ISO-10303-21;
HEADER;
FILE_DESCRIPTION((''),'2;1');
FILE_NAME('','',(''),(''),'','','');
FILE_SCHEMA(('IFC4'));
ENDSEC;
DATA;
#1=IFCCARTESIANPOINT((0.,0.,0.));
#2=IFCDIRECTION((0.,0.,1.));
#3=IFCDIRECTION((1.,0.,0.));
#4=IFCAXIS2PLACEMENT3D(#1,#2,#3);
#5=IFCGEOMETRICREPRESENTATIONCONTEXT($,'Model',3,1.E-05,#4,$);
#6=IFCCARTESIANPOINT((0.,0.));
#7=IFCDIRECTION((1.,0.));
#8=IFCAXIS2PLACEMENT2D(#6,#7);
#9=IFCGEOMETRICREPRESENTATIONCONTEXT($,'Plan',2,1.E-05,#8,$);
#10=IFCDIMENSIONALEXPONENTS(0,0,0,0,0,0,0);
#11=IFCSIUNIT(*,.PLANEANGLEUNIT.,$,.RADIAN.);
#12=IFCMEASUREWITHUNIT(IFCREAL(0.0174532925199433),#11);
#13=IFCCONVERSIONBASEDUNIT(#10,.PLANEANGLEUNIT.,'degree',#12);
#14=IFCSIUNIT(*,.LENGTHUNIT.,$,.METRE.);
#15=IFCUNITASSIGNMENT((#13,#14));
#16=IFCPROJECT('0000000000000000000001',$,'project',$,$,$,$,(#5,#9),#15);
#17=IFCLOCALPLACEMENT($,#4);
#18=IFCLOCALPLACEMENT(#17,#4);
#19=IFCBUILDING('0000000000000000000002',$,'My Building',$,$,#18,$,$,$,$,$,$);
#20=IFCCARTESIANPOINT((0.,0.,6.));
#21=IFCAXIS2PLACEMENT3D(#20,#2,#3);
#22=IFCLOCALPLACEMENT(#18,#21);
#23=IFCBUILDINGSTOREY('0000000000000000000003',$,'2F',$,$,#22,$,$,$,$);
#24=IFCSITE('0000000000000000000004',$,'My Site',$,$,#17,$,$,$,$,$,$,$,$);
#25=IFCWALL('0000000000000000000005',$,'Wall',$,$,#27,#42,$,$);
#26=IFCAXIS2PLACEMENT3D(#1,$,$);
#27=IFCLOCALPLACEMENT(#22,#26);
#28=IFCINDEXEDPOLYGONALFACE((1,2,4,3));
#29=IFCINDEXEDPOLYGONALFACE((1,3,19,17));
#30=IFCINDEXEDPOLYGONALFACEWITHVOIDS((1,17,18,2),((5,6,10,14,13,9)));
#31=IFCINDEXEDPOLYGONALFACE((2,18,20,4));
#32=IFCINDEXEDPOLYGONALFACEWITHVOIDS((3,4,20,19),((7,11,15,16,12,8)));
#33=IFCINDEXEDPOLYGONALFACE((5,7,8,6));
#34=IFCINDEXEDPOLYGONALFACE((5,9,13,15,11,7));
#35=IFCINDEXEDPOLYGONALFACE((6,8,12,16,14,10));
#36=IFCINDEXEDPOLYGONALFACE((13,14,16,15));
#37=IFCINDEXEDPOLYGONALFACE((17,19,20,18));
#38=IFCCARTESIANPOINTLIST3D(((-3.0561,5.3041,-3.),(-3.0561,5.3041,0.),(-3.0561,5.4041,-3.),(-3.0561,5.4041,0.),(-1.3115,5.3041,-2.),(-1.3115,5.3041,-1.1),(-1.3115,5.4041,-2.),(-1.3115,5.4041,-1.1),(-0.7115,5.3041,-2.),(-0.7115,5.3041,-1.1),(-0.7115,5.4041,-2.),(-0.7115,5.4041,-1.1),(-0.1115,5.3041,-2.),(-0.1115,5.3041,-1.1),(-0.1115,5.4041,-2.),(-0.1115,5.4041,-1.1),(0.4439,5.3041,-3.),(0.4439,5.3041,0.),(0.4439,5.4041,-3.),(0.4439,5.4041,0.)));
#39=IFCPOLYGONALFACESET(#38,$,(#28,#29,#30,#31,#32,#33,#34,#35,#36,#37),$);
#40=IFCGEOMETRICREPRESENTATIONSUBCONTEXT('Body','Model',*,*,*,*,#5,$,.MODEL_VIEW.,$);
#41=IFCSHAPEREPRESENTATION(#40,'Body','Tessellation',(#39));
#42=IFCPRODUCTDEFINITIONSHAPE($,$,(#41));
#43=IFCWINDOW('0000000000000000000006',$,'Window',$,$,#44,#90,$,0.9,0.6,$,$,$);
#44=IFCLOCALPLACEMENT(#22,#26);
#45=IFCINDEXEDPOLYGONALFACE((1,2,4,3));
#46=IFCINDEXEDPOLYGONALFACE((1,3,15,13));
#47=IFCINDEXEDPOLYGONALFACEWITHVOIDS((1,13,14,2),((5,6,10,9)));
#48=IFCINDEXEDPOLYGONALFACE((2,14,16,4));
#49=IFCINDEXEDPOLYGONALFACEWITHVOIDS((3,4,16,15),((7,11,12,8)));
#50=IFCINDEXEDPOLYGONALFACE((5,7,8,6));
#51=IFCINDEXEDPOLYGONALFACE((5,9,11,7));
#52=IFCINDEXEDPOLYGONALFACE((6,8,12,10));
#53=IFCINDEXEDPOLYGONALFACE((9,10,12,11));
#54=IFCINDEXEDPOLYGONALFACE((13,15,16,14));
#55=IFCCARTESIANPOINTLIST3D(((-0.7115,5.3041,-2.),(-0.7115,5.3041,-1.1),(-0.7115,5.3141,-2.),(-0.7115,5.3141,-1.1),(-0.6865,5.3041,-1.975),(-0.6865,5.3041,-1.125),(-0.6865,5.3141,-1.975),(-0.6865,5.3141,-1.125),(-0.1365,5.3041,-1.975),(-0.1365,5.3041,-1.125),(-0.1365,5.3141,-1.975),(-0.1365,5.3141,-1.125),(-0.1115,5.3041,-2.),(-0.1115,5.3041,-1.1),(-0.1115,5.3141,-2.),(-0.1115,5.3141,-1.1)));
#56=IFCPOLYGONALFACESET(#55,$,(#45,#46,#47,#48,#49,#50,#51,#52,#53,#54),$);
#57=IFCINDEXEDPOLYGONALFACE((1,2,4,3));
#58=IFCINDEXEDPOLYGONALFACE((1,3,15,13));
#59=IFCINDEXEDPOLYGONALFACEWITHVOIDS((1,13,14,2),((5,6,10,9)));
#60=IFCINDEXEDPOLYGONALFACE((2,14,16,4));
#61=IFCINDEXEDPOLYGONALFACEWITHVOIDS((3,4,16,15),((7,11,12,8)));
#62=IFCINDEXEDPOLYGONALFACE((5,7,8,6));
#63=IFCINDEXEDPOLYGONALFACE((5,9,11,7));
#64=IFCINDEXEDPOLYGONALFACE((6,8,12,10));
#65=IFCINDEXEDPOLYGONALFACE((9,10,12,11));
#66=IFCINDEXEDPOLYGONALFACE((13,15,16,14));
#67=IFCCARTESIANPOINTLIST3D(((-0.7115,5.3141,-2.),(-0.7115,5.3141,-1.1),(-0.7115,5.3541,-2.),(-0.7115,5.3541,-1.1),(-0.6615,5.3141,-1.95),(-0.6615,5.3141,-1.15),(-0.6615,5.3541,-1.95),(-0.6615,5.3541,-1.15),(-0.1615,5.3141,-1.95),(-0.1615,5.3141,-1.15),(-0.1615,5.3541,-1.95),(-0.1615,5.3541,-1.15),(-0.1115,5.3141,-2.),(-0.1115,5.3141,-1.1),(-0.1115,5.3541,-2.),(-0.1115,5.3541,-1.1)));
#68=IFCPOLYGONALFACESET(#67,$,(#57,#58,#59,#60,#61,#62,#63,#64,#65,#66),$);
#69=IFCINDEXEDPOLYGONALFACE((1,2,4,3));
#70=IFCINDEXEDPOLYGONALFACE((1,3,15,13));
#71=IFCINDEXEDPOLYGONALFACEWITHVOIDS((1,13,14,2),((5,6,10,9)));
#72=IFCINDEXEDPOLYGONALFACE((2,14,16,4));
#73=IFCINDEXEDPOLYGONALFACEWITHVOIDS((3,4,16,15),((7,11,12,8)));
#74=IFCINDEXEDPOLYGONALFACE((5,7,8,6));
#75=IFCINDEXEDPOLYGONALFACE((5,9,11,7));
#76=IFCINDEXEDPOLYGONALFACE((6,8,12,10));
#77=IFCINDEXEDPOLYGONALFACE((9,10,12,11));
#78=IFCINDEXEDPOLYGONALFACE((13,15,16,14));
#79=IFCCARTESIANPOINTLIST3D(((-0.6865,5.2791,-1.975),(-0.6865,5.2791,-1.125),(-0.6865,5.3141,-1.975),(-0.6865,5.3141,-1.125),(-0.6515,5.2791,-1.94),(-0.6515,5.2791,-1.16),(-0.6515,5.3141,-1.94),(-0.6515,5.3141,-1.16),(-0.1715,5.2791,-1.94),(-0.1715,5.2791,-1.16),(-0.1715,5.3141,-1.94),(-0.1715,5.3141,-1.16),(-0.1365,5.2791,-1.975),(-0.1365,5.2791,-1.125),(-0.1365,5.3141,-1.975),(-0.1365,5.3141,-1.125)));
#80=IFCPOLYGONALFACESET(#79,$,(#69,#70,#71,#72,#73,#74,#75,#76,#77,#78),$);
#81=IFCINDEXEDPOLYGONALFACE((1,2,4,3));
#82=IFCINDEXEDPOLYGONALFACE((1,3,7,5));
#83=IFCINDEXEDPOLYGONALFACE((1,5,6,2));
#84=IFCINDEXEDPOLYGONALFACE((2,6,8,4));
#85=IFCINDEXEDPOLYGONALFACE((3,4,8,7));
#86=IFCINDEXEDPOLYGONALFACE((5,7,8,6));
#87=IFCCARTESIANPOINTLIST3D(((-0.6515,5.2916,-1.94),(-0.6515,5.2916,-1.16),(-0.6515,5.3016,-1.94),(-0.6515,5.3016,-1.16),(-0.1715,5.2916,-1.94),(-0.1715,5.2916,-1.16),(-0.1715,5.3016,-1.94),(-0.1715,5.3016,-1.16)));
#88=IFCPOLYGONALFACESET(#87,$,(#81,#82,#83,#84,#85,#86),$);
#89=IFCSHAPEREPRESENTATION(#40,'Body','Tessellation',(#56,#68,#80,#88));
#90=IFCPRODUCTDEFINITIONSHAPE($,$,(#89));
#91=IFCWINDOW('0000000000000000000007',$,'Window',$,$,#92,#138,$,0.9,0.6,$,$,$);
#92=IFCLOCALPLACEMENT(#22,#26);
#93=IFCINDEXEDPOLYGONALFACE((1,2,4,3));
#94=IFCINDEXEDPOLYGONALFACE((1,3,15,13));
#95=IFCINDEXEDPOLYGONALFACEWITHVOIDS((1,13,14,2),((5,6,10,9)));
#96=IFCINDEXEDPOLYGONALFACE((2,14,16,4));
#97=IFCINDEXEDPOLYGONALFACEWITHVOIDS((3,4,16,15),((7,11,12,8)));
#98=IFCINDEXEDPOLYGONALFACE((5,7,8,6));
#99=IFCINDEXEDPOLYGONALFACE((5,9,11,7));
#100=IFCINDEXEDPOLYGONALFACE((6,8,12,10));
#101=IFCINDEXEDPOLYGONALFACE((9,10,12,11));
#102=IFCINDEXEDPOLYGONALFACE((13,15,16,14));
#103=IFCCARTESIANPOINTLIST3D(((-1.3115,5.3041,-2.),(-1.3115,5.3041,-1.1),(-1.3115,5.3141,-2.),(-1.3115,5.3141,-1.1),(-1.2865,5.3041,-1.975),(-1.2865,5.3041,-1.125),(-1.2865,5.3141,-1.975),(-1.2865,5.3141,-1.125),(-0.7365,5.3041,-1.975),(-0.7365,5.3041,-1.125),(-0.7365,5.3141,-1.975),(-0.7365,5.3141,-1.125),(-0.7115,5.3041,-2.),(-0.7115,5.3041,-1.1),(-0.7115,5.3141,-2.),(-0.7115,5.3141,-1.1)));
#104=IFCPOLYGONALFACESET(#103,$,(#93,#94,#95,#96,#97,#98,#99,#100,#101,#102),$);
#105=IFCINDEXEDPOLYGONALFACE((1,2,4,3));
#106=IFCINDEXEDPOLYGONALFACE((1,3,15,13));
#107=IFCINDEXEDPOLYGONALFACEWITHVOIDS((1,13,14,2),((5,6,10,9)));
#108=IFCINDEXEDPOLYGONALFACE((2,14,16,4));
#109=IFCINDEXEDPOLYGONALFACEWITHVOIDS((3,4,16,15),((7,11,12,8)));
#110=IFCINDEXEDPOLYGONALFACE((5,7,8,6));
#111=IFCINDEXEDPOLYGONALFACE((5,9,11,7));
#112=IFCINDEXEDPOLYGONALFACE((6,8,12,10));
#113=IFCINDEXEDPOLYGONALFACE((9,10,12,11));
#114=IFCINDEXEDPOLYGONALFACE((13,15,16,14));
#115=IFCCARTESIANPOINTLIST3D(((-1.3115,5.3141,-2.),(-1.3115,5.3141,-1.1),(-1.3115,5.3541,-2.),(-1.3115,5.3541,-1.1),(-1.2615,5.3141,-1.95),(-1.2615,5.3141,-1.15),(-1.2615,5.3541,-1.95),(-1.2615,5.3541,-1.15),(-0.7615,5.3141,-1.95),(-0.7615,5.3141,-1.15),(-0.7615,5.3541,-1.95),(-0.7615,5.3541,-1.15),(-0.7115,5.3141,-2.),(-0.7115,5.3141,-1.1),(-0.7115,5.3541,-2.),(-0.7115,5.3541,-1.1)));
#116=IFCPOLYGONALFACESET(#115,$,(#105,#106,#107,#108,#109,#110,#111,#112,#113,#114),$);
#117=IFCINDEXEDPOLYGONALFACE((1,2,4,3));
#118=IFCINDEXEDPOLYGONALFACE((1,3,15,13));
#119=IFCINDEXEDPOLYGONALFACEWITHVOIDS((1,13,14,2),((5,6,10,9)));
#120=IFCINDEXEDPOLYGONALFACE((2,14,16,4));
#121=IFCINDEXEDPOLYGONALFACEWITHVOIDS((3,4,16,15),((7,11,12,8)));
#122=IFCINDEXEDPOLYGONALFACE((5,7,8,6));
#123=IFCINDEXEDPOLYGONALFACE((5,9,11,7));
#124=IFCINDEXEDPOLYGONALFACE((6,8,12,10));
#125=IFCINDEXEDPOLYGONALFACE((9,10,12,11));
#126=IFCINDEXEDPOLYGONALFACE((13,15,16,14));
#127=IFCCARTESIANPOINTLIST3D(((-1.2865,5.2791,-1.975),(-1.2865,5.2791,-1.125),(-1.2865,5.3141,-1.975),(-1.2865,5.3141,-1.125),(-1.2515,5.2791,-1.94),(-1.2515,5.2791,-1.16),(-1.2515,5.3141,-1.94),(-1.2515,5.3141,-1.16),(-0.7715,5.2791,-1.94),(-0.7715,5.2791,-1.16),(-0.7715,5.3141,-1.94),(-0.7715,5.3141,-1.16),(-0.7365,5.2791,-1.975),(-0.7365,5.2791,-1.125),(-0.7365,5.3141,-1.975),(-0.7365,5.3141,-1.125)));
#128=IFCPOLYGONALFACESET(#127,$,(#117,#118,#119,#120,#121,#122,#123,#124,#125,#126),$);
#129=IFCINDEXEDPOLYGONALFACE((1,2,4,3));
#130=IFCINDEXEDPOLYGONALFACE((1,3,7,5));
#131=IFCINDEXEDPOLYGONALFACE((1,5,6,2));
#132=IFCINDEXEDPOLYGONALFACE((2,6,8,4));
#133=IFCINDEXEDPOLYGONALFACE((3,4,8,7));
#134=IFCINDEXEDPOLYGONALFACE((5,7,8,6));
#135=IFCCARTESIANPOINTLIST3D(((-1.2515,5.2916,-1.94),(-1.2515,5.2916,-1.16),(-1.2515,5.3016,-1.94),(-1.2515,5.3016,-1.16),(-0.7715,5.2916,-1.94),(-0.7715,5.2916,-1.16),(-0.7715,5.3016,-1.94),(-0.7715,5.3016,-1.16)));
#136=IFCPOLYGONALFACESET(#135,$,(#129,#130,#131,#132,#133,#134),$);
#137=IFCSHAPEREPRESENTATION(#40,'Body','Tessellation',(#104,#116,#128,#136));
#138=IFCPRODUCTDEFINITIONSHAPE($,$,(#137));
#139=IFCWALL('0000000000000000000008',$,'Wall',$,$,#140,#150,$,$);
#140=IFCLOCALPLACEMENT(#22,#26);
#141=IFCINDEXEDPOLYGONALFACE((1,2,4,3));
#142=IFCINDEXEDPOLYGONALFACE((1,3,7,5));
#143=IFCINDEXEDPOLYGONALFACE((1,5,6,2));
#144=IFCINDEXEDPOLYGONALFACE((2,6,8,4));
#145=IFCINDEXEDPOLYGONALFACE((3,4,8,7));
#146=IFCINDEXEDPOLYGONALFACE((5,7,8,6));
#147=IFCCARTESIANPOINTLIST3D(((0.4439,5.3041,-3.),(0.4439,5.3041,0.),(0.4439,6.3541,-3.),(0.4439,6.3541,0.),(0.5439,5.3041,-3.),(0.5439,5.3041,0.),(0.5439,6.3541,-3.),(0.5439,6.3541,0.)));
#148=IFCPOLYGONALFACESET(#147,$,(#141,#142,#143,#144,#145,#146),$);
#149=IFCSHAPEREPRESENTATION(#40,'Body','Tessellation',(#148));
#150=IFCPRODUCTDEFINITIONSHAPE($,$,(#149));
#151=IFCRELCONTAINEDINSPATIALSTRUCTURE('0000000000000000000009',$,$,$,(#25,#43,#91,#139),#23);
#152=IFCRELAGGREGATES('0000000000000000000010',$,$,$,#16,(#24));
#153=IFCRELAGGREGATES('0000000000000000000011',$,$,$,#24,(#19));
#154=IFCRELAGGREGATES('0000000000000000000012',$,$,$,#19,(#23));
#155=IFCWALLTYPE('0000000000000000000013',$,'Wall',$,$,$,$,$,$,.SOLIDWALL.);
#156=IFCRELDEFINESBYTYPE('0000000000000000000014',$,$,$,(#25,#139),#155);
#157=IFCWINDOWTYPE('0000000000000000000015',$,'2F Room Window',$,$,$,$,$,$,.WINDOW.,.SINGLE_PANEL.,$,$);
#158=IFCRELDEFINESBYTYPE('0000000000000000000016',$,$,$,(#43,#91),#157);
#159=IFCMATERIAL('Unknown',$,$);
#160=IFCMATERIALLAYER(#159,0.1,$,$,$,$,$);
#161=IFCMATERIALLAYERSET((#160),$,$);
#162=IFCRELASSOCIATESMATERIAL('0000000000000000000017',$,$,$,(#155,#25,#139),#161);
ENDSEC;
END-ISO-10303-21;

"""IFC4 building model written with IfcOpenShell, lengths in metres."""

from ifc_helpers import new_model, entity, si_unit, converted_unit, frame, origin_with_axes, origin_2d_with_axis, place, context, subcontext, project, spatial, line, indexed_curve, outline, extrude, shape, source, transform, mapped, material, layer, layer_set, layer_usage, type_object, type_shapes, element, fill, save


model = new_model("IFC4")

# Units and contexts
model_context = context("Model", 3, precision=1e-05, world=origin_with_axes())
plan_context = context("Plan", 2, precision=1e-05, world=origin_2d_with_axis())
body_context_1 = subcontext(model_context, "Body", "Model", "MODEL_VIEW")
body_context_2 = subcontext(plan_context, "Body", "Plan", "PLAN_VIEW")
ifc_project = project(units=[converted_unit("PLANEANGLEUNIT", "degree", entity("IfcReal", 0.0174532925199433), si_unit("PLANEANGLEUNIT", "RADIAN"), dimensions=[0, 0, 0, 0, 0, 0, 0]), si_unit("LENGTHUNIT", "METRE")], contexts=[model_context, plan_context])

# Site, building, storey
site_placement = place(None, origin_with_axes())
site = spatial("IfcSite", under=ifc_project, at=site_placement, Name="My Site")
building_placement = place(site_placement, origin_with_axes())
building = spatial("IfcBuilding", under=site, at=building_placement, Name="My Building")
storey_placement = place(building_placement, frame((0.0, 0.0, 6.0), z_axis=(0.0, 0.0, 1.0), x_axis=(1.0, 0.0, 0.0)))
storey = spatial("IfcBuildingStorey", under=building, at=storey_placement, Name="2F")

# Shared definitions
ifc_material = material(Name="Unknown")
ifc_layer = layer(ifc_material, 0.1)
ifc_layer_set = layer_set([ifc_layer])
wall_type = type_object("IfcWallType", Name="Wall", PredefinedType="SOLIDWALL", material=ifc_layer_set)

# Wall, openings, windows
shared_shape_1 = source(origin_with_axes(), body_context_1, "Body", "SweptSolid", [
    extrude(outline(indexed_curve([(0.0, 0.0), (0.6, 0.0), (0.6, 0.9), (0.0, 0.9)], segments=[line(1, 2, 3, 4, 1)])), frame((0.0, -0.6, 0.0), z_axis=(0.0, -1.0, 0.0), x_axis=(1.0, 0.0, 0.0)), (0.0, 0.0, -1.0), 1.2),
])
window_type_1 = type_object("IfcWindowType", Name="2F Room Window", PartitioningType="SINGLE_PANEL", PredefinedType="WINDOW")
shared_shape_2 = source(origin_with_axes(), body_context_1, "Body", "SweptSolid", [
    extrude(outline(indexed_curve([(0.0, 0.0), (0.6, 0.0), (0.6, 0.9), (0.0, 0.9)], segments=[line(1, 2, 3, 4, 1)]), holes=[indexed_curve([(0.025, 0.025), (0.575, 0.025), (0.575, 0.875), (0.025, 0.875)], segments=[line(1, 2, 3, 4, 1)])]), frame((0.0, 0.09, 0.0), z_axis=(0.0, -1.0, 0.0), x_axis=(1.0, 0.0, 0.0)), (0.0, 0.0, -1.0), 0.01),
    extrude(outline(indexed_curve([(0.0, 0.0), (0.6, 0.0), (0.6, 0.9), (0.0, 0.9)], segments=[line(1, 2, 3, 4, 1)]), holes=[indexed_curve([(0.05, 0.05), (0.55, 0.05), (0.55, 0.85), (0.05, 0.85)], segments=[line(1, 2, 3, 4, 1)])]), frame((0.0, 0.05, 0.0), z_axis=(0.0, -1.0, 0.0), x_axis=(1.0, 0.0, 0.0)), (0.0, 0.0, -1.0), 0.04),
    extrude(outline(indexed_curve([(0.0, 0.0), (0.55, 0.0), (0.55, 0.85), (0.0, 0.85)], segments=[line(1, 2, 3, 4, 1)]), holes=[indexed_curve([(0.035, 0.035), (0.515, 0.035), (0.515, 0.815), (0.035, 0.815)], segments=[line(1, 2, 3, 4, 1)])]), frame((0.025, 0.09, 0.025), z_axis=(0.0, -1.0, 0.0), x_axis=(1.0, 0.0, 0.0)), (0.0, 0.0, -1.0), 0.035),
    extrude(outline(indexed_curve([(0.035, 0.035), (0.515, 0.035), (0.515, 0.815), (0.035, 0.815)], segments=[line(1, 2, 3, 4, 1)])), frame((0.025, 0.1025, 0.025), z_axis=(0.0, -1.0, 0.0), x_axis=(1.0, 0.0, 0.0)), (0.0, 0.0, -1.0), 0.01),
])
shared_shape_3 = source(origin_with_axes(), body_context_2, "Body", "Curve2D", [
    entity("IfcIndexedPolyCurve", entity("IfcCartesianPointList2D", [[0.05, 0.05], [0.55, 0.05]])),
    entity("IfcIndexedPolyCurve", entity("IfcCartesianPointList2D", [[0.0, 0.1], [0.025, 0.1], [0.025, 0.09], [0.05, 0.09], [0.05, 0.05], [0.0, 0.05]]), [entity("IfcLineIndex", [1, 2, 3, 4, 5, 6, 1])]),
    entity("IfcIndexedPolyCurve", entity("IfcCartesianPointList2D", [[0.6, 0.1], [0.575, 0.1], [0.575, 0.09], [0.55, 0.09], [0.55, 0.05], [0.6, 0.05]]), [entity("IfcLineIndex", [1, 2, 3, 4, 5, 6, 1])]),
    entity("IfcIndexedPolyCurve", entity("IfcCartesianPointList2D", [[0.025, 0.09], [0.06, 0.09], [0.06, 0.125], [0.025, 0.125]]), [entity("IfcLineIndex", [1, 2, 3, 4, 1])]),
    entity("IfcIndexedPolyCurve", entity("IfcCartesianPointList2D", [[0.575, 0.09], [0.54, 0.09], [0.54, 0.125], [0.575, 0.125]]), [entity("IfcLineIndex", [1, 2, 3, 4, 1])]),
    entity("IfcIndexedPolyCurve", entity("IfcCartesianPointList2D", [[0.06, 0.09], [0.54, 0.09]])),
    entity("IfcIndexedPolyCurve", entity("IfcCartesianPointList2D", [[0.06, 0.125], [0.54, 0.125]])),
    entity("IfcIndexedPolyCurve", entity("IfcCartesianPointList2D", [[0.06, 0.1075], [0.54, 0.1075]])),
])
type_shapes(window_type_1, [shared_shape_2, shared_shape_3])
ifc_layer_usage_1 = layer_usage(ifc_layer_set, "AXIS2", "POSITIVE", 0.0)
wall_1_placement = place(storey_placement, frame((0.4439, 5.4041, -3.0), z_axis=(0.0, 0.0, 1.0), x_axis=(-1.0, 0.0, 0.0)))
wall_1 = element("IfcWall", 1, at=wall_1_placement, inside=storey, type_object=wall_type, material=ifc_layer_usage_1, Name="Wall", context=body_context_1, shape_type="SweptSolid", body=[
    extrude(outline(indexed_curve([(0.0, 0.0), (0.0, 0.1), (3.5, 0.1), (3.5, 0.0)], segments=[line(1, 2, 3, 4, 1)])), origin_with_axes(), (0.0, 0.0, 1.0), 3.0),
])
opening_1_placement = place(wall_1_placement, frame((0.5555, 0.0, 1.0), z_axis=(0.0, 0.0, 1.0), x_axis=(1.0, 0.0, 0.0)))
opening_1 = element("IfcOpeningElement", 2, at=opening_1_placement, cuts=wall_1, PredefinedType="OPENING", context=body_context_1, shape_type="MappedRepresentation", body=[
    mapped(shared_shape_1, transform((0.0, 0.0, 0.0), x_axis=(1.0, 0.0, 0.0), y_axis=(0.0, 1.0, 0.0), z_axis=(0.0, 0.0, 1.0), scale=1.0)),
])
opening_2_placement = place(wall_1_placement, frame((1.1555, 0.0, 1.0), z_axis=(0.0, 0.0, 1.0), x_axis=(1.0, 0.0, 0.0)))
opening_2 = element("IfcOpeningElement", 3, at=opening_2_placement, cuts=wall_1, PredefinedType="OPENING", context=body_context_1, shape_type="MappedRepresentation", body=[
    mapped(shared_shape_1, transform((0.0, 0.0, 0.0), x_axis=(1.0, 0.0, 0.0), y_axis=(0.0, 1.0, 0.0), z_axis=(0.0, 0.0, 1.0), scale=1.0)),
])
window_1_placement = place(opening_1_placement, origin_with_axes())
window_1 = element("IfcWindow", 4, at=window_1_placement, inside=storey, type_object=window_type_1, Name="Window", OverallHeight=0.9, OverallWidth=0.6, shapes=[
    shape(body_context_1, "Body", "MappedRepresentation", [mapped(shared_shape_2, transform((0.0, 0.0, 0.0), x_axis=(1.0, 0.0, 0.0), y_axis=(0.0, 1.0, 0.0), z_axis=(0.0, 0.0, 1.0), scale=1.0))]),
    shape(body_context_2, "Body", "MappedRepresentation", [mapped(shared_shape_3, transform((0.0, 0.0, 0.0), x_axis=(1.0, 0.0, 0.0), y_axis=(0.0, 1.0, 0.0), z_axis=(0.0, 0.0, 1.0), scale=1.0))]),
])
fill(opening_1, window_1)
window_2_placement = place(opening_2_placement, origin_with_axes())
window_2 = element("IfcWindow", 5, at=window_2_placement, inside=storey, type_object=window_type_1, Name="Window", OverallHeight=0.9, OverallWidth=0.6, shapes=[
    shape(body_context_1, "Body", "MappedRepresentation", [mapped(shared_shape_2, transform((0.0, 0.0, 0.0), x_axis=(1.0, 0.0, 0.0), y_axis=(0.0, 1.0, 0.0), z_axis=(0.0, 0.0, 1.0), scale=1.0))]),
    shape(body_context_2, "Body", "MappedRepresentation", [mapped(shared_shape_3, transform((0.0, 0.0, 0.0), x_axis=(1.0, 0.0, 0.0), y_axis=(0.0, 1.0, 0.0), z_axis=(0.0, 0.0, 1.0), scale=1.0))]),
])
fill(opening_2, window_2)

# Wall
ifc_layer_usage_2 = layer_usage(ifc_layer_set, "AXIS2", "POSITIVE", 0.0)
wall_2_placement = place(storey_placement, frame((0.4439, 6.3541, -3.0), z_axis=(0.0, 0.0, 1.0), x_axis=(0.0, -1.0, 0.0)))
element("IfcWall", 6, at=wall_2_placement, inside=storey, type_object=wall_type, material=ifc_layer_usage_2, Name="Wall", context=body_context_1, shape_type="SweptSolid", body=[
    extrude(outline(indexed_curve([(0.0, 0.0), (0.0, 0.1), (1.05, 0.1), (1.05, 0.0)], segments=[line(1, 2, 3, 4, 1)])), origin_with_axes(), (0.0, 0.0, 1.0), 3.0),
])

save(model, "model.ifc")
